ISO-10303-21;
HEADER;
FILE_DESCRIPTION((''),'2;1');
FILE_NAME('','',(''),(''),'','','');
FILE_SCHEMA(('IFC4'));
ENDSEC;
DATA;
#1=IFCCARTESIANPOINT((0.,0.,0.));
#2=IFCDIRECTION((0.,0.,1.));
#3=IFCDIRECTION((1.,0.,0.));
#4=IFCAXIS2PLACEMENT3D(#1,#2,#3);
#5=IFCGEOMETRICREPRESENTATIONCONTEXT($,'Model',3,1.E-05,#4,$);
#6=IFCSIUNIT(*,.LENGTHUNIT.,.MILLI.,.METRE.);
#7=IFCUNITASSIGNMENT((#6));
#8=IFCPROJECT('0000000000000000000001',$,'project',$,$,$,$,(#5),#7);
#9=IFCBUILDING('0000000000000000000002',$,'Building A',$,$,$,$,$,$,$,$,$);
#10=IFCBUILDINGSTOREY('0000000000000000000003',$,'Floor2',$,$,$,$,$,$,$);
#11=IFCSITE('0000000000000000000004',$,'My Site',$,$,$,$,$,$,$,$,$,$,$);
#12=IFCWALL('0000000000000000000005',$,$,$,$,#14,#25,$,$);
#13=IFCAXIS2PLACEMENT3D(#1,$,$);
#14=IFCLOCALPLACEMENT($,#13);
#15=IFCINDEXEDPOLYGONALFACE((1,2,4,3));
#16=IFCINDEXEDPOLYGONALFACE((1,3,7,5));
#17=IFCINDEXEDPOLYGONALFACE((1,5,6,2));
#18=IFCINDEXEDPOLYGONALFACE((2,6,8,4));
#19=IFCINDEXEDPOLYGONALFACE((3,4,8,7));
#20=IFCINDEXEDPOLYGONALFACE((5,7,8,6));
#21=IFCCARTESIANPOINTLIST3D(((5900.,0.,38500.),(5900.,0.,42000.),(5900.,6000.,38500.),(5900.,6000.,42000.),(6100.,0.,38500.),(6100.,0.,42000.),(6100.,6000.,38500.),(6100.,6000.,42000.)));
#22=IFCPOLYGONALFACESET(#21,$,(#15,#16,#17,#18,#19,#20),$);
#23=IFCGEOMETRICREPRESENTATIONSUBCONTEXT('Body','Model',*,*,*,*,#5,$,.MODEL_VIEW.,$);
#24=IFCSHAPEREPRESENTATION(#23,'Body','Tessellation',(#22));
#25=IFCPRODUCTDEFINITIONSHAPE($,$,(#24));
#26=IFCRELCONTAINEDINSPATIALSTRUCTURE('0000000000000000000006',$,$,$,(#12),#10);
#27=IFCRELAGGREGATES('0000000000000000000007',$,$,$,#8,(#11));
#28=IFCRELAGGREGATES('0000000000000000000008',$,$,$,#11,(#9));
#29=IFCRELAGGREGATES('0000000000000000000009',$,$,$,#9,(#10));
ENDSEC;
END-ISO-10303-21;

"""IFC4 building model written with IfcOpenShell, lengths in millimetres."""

from ifc_helpers import new_model, si_unit, frame, origin_with_axes, place, context, subcontext, project, spatial, indexed_curve, outline, extrude, element, save


model = new_model("IFC4")

# Units and contexts
model_context = context("Model", 3, precision=1e-05, world=origin_with_axes())
body_context = subcontext(model_context, "Body", "Model", "MODEL_VIEW")
ifc_project = project(units=[si_unit("LENGTHUNIT", "METRE", prefix="MILLI")], contexts=[model_context])

# Site, building, storey
site = spatial("IfcSite", under=ifc_project, Name="My Site")
building = spatial("IfcBuilding", under=site, Name="Building A")
storey = spatial("IfcBuildingStorey", under=building, Name="Floor2")

# Wall
wall_placement = place(None, frame((6100.0, 0.0, 38500.0), z_axis=(0.0, 0.0, 1.0), x_axis=(0.0, 1.0, 0.0)))
element("IfcWall", 1, at=wall_placement, inside=storey, context=body_context, shape_type="SweptSolid", body=[
    extrude(outline(indexed_curve([(0.0, 0.0), (0.0, 200.0), (6000.0, 200.0), (6000.0, 0.0), (0.0, 0.0)], self_intersect=False)), origin_with_axes(), (0.0, 0.0, 1.0), 3500.0),
])

save(model, "model.ifc")
